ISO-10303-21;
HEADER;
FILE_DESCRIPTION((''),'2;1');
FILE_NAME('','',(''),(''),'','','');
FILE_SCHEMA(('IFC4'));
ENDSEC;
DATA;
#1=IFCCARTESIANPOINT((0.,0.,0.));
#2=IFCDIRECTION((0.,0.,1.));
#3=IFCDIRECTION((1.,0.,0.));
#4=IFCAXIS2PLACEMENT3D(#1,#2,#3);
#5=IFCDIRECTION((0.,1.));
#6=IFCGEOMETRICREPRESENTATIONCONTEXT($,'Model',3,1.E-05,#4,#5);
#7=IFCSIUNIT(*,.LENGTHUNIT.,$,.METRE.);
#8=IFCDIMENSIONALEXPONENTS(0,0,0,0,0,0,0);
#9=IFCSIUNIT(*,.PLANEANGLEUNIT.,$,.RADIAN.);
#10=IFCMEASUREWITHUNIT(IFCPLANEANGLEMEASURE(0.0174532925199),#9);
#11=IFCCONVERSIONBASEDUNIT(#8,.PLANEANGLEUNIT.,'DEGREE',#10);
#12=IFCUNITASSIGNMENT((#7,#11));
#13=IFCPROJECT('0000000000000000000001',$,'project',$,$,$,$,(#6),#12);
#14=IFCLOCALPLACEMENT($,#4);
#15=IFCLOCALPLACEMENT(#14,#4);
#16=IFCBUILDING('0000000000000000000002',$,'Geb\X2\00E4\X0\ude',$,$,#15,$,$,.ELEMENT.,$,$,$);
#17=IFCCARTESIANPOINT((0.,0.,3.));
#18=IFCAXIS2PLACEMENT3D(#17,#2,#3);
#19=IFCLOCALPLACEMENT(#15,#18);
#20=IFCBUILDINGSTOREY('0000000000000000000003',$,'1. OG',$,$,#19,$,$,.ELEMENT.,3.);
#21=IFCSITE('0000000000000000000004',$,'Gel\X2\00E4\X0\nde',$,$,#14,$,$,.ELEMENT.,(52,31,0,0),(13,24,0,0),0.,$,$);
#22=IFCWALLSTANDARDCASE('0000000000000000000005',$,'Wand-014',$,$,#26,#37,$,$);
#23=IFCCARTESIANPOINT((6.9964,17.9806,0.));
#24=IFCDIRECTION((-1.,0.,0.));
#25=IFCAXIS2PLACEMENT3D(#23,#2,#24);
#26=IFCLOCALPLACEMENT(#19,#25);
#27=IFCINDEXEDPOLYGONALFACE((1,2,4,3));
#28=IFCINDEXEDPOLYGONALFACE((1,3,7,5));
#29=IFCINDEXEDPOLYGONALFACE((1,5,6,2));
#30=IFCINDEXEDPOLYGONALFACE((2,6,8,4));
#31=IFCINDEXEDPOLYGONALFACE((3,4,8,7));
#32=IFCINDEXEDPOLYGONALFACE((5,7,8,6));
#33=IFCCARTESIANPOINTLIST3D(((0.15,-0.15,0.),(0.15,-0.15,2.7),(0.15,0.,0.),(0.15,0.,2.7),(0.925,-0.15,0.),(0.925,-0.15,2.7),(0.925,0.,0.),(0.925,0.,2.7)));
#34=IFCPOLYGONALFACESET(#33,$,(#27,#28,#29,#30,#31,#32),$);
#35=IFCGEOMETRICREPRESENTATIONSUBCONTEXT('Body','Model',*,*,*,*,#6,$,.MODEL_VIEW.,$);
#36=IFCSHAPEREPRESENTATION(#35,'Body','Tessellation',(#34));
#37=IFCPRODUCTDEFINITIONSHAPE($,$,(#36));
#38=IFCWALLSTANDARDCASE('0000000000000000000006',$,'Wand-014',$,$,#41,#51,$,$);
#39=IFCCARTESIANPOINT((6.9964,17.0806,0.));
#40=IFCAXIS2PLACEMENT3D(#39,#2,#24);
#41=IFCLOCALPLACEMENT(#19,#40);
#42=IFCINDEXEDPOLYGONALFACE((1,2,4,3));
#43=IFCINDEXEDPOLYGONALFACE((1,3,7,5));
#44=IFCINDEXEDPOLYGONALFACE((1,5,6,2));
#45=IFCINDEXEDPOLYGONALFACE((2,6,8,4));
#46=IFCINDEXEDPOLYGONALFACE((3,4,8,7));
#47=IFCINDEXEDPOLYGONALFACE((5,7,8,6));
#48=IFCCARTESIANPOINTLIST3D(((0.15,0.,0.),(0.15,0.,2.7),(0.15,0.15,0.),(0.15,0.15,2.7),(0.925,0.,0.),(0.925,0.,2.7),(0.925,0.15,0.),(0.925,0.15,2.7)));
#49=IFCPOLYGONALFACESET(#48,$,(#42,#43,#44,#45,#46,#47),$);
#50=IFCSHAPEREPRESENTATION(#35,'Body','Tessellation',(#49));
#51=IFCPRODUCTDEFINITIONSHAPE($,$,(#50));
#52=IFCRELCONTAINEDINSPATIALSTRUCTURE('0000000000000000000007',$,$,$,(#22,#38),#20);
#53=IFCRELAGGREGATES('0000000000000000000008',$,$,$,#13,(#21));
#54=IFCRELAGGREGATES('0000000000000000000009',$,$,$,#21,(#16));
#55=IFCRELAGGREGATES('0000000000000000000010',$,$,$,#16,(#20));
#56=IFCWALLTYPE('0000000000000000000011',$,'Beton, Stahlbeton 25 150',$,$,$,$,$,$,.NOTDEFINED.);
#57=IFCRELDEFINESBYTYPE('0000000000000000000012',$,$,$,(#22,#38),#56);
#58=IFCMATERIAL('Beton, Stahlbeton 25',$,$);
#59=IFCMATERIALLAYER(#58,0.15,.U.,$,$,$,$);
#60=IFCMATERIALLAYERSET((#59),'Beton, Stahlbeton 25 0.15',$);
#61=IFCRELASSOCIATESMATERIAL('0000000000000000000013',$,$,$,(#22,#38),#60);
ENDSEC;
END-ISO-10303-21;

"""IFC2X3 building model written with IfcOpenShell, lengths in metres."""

from ifc_helpers import new_model, entity, si_unit, converted_unit, direction, frame, origin_with_axes, place, context, subcontext, project, spatial, polyline, outline, extrude, material, layer, layer_set, layer_usage, type_object, element, save


model = new_model("IFC2X3")

# Units and contexts
model_context = context("Model", 3, precision=1e-05, world=origin_with_axes(), true_north=direction((0.0, 1.0)))
body_context = subcontext(model_context, "Body", "Model", "MODEL_VIEW")
ifc_project = project(units=[si_unit("LENGTHUNIT", "METRE"), converted_unit("PLANEANGLEUNIT", "DEGREE", entity("IfcPlaneAngleMeasure", 0.0174532925199), si_unit("PLANEANGLEUNIT", "RADIAN"), dimensions=[0, 0, 0, 0, 0, 0, 0])], contexts=[model_context])

# Site, building, storey
site_placement = place(None, origin_with_axes())
site = spatial("IfcSite", under=ifc_project, at=site_placement, Name="Gelände", CompositionType="ELEMENT", RefLatitude=(52, 31, 0, 0), RefLongitude=(13, 24, 0, 0), RefElevation=0.0)
building_placement = place(site_placement, origin_with_axes())
building = spatial("IfcBuilding", under=site, at=building_placement, Name="Gebäude", CompositionType="ELEMENT")
storey_placement = place(building_placement, frame((0.0, 0.0, 3.0), z_axis=(0.0, 0.0, 1.0), x_axis=(1.0, 0.0, 0.0)))
storey = spatial("IfcBuildingStorey", under=building, at=storey_placement, Name="1. OG", CompositionType="ELEMENT", Elevation=3.0)

# Shared definitions
ifc_material_1 = material(Name="Beton, Stahlbeton 25")

# Shared definitions
ifc_layer_1 = layer(ifc_material_1, 0.15, ventilated="UNKNOWN")
ifc_layer_set_1 = layer_set([ifc_layer_1], Name="Beton, Stahlbeton 25 0.15")
wall_type_1 = type_object("IfcWallType", Name="Beton, Stahlbeton 25 150", PredefinedType="NOTDEFINED")

# Walls
ifc_layer_usage_1 = layer_usage(ifc_layer_set_1, "AXIS2", "NEGATIVE", 0.0)
wall_1_placement = place(storey_placement, frame((6.9964, 17.9806, 0.0), z_axis=(0.0, 0.0, 1.0), x_axis=(-1.0, 0.0, 0.0)))
element("IfcWallStandardCase", 1, at=wall_1_placement, inside=storey, type_object=wall_type_1, material=ifc_layer_usage_1, Name="Wand-014", context=body_context, shape_type="SweptSolid", body=[
    extrude(outline(polyline([(0.15, -0.15), (0.925, -0.15), (0.925, 0.0), (0.15, 0.0), (0.15, -0.15)])), origin_with_axes(), (0.0, 0.0, 1.0), 2.7),
])
ifc_layer_usage_2 = layer_usage(ifc_layer_set_1, "AXIS2", "POSITIVE", 0.0)
wall_2_placement = place(storey_placement, frame((6.9964, 17.0806, 0.0), z_axis=(0.0, 0.0, 1.0), x_axis=(-1.0, 0.0, 0.0)))
element("IfcWallStandardCase", 2, at=wall_2_placement, inside=storey, type_object=wall_type_1, material=ifc_layer_usage_2, Name="Wand-014", context=body_context, shape_type="SweptSolid", body=[
    extrude(outline(polyline([(0.15, 0.0), (0.925, 0.0), (0.925, 0.15), (0.15, 0.15), (0.15, 0.0)])), origin_with_axes(), (0.0, 0.0, 1.0), 2.7),
])

save(model, "model.ifc")
